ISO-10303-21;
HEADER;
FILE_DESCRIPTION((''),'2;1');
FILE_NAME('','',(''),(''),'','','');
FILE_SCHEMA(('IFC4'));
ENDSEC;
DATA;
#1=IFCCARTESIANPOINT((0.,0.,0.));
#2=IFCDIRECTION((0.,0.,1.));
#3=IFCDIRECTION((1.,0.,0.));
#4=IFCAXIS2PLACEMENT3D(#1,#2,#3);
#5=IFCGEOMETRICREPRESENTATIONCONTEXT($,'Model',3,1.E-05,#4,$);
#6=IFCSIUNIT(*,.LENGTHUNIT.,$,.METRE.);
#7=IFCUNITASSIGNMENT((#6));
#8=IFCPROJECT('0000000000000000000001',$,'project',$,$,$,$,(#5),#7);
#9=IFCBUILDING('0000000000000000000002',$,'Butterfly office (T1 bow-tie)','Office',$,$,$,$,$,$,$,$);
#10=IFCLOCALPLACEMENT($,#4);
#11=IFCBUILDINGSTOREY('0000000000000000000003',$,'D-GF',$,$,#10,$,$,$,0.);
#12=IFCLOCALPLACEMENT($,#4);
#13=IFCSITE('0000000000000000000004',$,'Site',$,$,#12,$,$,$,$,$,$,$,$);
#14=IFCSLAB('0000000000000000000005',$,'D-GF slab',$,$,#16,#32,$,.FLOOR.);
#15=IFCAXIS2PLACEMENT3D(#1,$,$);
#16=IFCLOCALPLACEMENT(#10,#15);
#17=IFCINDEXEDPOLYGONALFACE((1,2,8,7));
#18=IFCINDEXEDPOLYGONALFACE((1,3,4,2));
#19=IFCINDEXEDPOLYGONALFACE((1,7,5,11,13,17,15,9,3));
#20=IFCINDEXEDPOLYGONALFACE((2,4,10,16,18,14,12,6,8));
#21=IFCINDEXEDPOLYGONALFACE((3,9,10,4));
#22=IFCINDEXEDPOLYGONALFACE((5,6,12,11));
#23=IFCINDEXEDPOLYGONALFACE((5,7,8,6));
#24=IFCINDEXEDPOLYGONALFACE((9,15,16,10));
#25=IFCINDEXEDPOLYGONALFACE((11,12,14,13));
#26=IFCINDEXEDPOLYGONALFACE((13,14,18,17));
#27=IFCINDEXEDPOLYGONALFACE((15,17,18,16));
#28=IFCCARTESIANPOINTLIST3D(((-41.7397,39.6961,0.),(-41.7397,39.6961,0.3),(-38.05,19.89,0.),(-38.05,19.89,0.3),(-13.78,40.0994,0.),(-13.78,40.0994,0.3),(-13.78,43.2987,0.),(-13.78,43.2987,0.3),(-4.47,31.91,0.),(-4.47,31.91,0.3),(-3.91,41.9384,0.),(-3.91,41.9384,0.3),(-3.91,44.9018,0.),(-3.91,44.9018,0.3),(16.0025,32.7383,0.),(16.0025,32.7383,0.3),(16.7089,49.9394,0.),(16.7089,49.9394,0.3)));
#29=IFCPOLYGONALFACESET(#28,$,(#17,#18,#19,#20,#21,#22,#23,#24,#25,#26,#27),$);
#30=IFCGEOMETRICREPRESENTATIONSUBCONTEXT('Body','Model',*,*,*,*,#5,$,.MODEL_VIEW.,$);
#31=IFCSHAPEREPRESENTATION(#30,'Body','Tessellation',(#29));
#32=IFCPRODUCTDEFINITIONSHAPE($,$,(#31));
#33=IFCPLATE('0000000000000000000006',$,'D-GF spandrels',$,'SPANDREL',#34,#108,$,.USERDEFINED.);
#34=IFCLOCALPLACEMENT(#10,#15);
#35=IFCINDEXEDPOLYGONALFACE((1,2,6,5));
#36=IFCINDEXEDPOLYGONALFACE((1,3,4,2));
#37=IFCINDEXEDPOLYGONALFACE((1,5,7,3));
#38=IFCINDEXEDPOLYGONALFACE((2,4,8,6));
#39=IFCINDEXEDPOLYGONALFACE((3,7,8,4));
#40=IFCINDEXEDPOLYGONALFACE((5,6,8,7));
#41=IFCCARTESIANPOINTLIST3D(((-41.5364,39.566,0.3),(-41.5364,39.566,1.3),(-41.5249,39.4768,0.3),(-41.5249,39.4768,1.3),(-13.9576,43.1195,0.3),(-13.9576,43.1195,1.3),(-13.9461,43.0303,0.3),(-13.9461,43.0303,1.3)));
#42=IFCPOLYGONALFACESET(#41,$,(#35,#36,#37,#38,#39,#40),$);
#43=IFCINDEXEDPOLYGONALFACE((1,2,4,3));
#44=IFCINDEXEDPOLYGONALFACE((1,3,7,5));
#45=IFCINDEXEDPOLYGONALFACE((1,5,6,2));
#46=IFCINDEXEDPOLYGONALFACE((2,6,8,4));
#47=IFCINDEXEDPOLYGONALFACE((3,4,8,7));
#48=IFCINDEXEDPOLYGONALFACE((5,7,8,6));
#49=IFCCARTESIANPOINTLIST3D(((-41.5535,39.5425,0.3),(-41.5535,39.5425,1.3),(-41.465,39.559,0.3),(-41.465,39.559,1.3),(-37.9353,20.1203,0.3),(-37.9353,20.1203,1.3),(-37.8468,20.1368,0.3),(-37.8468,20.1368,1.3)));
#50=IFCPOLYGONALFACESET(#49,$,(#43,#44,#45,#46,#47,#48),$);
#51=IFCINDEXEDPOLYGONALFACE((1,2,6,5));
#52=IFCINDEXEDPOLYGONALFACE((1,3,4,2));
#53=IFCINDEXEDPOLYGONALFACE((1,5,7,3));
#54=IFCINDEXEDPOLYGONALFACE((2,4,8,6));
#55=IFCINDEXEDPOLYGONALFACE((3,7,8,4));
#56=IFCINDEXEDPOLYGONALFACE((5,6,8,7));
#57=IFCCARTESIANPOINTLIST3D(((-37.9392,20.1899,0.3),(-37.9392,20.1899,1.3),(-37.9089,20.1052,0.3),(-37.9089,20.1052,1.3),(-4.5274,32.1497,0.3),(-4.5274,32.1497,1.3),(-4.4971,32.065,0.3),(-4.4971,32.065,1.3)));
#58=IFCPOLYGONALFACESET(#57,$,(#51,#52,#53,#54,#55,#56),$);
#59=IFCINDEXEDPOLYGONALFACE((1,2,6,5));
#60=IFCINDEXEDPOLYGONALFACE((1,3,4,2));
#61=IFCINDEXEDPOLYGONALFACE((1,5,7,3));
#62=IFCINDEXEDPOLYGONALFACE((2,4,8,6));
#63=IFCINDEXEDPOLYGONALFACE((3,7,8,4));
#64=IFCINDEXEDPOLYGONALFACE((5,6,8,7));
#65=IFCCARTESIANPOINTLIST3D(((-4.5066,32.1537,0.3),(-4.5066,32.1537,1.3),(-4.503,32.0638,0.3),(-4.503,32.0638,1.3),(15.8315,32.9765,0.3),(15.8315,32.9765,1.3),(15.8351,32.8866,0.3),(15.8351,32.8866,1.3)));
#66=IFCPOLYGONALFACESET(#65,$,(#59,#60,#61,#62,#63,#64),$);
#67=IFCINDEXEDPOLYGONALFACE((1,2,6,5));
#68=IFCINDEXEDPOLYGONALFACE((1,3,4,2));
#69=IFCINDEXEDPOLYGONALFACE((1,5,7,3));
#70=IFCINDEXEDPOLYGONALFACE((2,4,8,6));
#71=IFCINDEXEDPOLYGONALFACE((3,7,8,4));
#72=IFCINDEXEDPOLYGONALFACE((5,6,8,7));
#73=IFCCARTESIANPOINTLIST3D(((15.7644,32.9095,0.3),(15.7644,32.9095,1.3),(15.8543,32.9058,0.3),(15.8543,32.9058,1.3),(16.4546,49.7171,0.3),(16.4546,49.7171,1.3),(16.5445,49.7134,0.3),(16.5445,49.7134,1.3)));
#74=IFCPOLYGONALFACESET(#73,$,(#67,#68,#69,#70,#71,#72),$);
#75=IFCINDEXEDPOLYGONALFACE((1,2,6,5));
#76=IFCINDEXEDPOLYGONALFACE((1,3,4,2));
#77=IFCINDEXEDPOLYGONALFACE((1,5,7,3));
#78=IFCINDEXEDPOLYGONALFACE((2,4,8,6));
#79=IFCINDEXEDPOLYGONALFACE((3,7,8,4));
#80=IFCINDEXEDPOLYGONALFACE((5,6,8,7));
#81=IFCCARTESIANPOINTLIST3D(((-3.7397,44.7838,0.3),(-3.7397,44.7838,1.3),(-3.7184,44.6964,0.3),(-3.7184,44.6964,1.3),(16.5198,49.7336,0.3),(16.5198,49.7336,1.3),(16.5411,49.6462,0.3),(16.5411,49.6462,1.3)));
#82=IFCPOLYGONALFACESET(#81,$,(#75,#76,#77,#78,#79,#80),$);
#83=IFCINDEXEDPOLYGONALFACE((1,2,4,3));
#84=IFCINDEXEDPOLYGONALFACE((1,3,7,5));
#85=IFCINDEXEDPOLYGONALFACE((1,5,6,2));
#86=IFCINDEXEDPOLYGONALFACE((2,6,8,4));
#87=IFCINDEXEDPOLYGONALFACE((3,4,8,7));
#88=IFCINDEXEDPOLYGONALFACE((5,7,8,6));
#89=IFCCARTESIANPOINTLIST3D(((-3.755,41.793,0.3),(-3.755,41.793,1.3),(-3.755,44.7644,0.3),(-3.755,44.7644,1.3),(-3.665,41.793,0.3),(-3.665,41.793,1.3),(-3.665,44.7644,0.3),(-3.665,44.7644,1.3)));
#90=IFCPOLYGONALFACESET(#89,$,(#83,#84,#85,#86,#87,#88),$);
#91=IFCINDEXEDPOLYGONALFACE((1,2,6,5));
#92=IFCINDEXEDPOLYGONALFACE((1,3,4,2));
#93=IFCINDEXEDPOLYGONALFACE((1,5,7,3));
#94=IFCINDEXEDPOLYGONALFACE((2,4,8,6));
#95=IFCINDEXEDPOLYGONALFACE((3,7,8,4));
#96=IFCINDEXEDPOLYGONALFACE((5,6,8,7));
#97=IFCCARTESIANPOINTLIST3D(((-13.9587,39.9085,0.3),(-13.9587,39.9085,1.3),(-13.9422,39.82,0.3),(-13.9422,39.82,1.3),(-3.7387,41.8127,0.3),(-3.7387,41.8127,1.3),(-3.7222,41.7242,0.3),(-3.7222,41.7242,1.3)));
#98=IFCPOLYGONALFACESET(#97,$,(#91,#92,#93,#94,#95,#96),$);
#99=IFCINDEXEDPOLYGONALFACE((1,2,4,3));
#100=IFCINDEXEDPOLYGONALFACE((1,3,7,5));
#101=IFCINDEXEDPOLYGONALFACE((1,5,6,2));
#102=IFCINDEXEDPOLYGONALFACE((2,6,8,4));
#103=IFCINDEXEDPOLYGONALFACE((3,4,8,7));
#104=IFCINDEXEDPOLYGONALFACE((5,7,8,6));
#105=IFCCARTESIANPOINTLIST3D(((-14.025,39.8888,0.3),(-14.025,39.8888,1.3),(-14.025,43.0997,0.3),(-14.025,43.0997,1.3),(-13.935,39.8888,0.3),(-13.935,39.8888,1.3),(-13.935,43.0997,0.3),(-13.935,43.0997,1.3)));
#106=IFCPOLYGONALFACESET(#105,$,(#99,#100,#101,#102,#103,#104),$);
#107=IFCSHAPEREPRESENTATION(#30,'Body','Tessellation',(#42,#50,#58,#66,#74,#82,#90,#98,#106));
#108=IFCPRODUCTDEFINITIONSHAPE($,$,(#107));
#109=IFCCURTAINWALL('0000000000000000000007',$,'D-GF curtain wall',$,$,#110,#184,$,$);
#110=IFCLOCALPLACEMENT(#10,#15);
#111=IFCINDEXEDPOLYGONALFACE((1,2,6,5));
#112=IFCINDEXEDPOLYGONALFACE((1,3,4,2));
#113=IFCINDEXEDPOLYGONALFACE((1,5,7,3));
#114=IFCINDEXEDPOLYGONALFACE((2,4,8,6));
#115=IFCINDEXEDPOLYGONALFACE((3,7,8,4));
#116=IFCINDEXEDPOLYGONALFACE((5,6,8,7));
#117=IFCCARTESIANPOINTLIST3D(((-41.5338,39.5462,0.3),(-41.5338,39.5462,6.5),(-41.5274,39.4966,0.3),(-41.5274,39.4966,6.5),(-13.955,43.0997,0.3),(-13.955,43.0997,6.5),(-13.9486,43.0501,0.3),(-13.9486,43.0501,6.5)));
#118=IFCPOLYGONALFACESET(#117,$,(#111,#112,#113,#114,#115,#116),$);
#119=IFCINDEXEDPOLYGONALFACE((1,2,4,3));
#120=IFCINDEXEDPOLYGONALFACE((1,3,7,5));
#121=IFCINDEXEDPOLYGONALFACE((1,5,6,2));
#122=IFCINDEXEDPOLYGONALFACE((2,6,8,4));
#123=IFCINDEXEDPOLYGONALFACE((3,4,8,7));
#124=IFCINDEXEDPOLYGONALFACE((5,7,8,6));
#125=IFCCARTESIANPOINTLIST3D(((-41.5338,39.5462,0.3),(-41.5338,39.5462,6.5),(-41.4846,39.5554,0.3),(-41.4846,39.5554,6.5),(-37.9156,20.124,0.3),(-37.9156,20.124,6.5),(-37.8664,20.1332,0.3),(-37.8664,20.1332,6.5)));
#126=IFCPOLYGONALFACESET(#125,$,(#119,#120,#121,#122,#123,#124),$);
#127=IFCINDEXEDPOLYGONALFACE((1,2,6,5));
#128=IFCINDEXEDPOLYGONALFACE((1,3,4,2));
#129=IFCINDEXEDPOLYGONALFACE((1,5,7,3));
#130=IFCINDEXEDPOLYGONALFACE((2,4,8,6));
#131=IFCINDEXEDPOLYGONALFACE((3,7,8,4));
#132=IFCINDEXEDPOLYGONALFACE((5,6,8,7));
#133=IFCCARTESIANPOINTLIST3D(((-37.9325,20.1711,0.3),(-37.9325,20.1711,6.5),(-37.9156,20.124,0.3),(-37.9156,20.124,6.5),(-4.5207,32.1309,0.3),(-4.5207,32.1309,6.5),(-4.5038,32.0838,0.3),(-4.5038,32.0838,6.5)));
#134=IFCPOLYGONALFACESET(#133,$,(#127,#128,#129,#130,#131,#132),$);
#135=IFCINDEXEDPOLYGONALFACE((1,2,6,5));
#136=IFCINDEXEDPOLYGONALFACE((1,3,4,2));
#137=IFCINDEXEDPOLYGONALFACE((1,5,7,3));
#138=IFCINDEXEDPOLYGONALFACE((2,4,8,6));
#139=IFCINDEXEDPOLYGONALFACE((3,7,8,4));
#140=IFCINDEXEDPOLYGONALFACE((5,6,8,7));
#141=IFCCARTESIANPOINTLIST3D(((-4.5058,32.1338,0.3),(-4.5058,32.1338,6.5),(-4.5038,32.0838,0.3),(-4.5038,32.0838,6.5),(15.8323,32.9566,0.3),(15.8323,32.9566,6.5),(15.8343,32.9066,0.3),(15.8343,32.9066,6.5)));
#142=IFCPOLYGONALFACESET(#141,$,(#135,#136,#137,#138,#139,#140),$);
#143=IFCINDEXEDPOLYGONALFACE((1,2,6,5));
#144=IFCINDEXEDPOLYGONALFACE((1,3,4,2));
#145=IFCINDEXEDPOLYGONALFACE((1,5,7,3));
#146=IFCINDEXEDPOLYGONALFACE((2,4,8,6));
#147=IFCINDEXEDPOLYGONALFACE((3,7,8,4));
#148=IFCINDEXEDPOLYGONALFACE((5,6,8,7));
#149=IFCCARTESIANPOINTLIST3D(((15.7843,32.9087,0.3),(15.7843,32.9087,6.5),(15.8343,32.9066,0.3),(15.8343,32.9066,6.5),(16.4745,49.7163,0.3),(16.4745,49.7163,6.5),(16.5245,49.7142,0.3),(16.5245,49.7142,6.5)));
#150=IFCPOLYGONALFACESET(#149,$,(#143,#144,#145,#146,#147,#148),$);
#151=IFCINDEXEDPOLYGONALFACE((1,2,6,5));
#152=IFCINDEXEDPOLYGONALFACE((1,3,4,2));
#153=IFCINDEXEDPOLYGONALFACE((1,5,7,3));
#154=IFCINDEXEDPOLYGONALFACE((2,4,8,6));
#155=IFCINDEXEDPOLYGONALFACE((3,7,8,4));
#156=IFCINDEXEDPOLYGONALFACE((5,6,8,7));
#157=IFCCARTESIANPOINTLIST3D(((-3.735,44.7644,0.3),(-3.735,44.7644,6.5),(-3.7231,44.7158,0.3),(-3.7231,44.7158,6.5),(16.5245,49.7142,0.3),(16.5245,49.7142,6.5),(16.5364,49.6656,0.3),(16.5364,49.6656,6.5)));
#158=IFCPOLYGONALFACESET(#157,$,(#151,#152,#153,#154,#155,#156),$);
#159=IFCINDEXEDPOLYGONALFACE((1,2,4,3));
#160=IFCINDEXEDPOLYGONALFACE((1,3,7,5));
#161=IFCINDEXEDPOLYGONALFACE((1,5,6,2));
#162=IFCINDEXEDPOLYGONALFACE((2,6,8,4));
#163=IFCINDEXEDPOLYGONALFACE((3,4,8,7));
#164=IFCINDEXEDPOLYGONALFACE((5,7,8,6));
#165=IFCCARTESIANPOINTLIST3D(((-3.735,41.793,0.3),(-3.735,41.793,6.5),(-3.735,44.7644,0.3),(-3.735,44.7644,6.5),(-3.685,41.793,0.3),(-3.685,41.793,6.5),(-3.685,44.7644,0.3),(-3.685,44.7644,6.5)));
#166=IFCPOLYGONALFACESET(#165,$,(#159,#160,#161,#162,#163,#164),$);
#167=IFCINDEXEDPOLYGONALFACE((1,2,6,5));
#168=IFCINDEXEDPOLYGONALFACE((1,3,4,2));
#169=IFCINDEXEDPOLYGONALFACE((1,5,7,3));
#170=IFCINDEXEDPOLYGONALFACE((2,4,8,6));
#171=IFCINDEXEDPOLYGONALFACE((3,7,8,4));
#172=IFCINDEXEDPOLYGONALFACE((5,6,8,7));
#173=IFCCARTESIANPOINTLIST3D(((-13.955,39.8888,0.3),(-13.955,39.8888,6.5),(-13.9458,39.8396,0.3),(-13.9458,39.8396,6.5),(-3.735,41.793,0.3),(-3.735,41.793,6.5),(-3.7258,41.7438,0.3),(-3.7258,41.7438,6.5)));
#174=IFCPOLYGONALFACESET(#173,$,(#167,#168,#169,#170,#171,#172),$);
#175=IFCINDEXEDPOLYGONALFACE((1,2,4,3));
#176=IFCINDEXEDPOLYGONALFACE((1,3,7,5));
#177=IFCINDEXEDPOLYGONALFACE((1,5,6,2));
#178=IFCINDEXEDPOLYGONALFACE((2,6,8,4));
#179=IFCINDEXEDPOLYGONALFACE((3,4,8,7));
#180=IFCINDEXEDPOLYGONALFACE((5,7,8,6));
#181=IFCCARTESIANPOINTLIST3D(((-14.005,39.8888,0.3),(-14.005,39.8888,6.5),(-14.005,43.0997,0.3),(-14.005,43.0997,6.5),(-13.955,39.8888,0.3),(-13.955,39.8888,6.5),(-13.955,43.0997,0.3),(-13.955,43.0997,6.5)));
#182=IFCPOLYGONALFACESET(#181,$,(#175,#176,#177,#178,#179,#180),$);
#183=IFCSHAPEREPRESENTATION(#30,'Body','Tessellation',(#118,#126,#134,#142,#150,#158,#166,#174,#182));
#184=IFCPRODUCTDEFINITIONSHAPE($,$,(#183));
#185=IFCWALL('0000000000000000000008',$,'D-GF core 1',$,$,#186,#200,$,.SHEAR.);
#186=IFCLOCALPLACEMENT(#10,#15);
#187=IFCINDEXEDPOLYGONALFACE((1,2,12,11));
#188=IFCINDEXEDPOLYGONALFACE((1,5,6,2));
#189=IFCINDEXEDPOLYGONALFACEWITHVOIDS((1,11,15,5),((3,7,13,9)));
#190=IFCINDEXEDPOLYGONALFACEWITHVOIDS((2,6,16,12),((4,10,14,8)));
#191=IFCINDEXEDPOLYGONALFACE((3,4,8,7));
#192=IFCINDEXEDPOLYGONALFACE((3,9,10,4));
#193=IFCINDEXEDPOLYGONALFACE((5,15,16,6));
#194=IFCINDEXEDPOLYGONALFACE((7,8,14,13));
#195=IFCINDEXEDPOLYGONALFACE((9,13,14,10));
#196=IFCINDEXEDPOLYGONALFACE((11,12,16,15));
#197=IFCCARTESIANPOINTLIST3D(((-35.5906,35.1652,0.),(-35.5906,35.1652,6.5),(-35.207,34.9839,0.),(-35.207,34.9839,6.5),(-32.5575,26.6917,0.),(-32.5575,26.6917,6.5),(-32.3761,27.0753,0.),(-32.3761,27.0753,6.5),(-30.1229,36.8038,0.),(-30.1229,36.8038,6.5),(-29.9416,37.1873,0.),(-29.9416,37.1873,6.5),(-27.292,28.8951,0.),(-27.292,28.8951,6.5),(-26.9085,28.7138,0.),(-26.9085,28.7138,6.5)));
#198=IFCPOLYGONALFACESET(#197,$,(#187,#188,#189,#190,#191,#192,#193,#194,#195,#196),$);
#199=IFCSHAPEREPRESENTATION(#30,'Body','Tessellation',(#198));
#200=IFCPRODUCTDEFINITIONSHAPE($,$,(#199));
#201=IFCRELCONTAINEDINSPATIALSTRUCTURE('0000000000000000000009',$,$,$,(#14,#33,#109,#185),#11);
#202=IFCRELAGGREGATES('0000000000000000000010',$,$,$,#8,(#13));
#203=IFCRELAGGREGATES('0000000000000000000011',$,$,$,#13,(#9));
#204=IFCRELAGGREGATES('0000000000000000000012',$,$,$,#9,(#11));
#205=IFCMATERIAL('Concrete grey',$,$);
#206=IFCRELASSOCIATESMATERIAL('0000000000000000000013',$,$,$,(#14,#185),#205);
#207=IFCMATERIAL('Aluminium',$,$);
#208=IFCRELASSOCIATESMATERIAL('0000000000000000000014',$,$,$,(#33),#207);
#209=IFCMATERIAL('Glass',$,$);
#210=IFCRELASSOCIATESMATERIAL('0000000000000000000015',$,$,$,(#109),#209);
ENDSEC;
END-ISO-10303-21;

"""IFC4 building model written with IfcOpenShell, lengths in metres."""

from ifc_helpers import new_model, si_unit, frame, origin_with_axes, place, context, subcontext, project, spatial, polyline, outline, extrude, material, element, save


model = new_model("IFC4")

# Units and contexts
model_context = context("Model", 3, precision=1e-05, world=origin_with_axes())
body_context = subcontext(model_context, "Body", "Model", "MODEL_VIEW")
ifc_project = project(units=[si_unit("LENGTHUNIT", "METRE")], contexts=[model_context])

# Site, building, storey
site_placement = place(None, origin_with_axes())
site = spatial("IfcSite", under=ifc_project, at=site_placement, Name="Site")
building = spatial("IfcBuilding", under=site, Name="Butterfly office (T1 bow-tie)", Description="Office")
storey_placement = place(None, origin_with_axes())
storey = spatial("IfcBuildingStorey", under=building, at=storey_placement, Name="D-GF", Elevation=0.0)

# Shared definitions
ifc_material_1 = material(Name="Aluminium")

# Slab
ifc_material_2 = material(Name="Concrete grey")
slab_placement = place(storey_placement, origin_with_axes())
element("IfcSlab", 1, at=slab_placement, inside=storey, material=ifc_material_2, Name="D-GF slab", PredefinedType="FLOOR", context=body_context, shape_type="SweptSolid", body=[
    extrude(outline(polyline([(-13.78, 43.2987), (-41.7397, 39.6961), (-38.05, 19.89), (-4.47, 31.91), (16.0025, 32.7383), (16.7089, 49.9394), (-3.91, 44.9018), (-3.91, 41.9384), (-13.78, 40.0994), (-13.78, 43.2987)])), origin_with_axes(), (0.0, 0.0, 1.0), 0.3),
])

# Plate
plate_placement = place(storey_placement, origin_with_axes())
element("IfcPlate", 2, at=plate_placement, inside=storey, material=ifc_material_1, Name="D-GF spandrels", ObjectType="SPANDREL", PredefinedType="USERDEFINED", context=body_context, shape_type="SweptSolid", body=[
    extrude(outline(polyline([(-13.9576, 43.1195), (-41.5364, 39.566), (-41.5249, 39.4768), (-13.9461, 43.0303), (-13.9576, 43.1195)])), frame((0.0, 0.0, 0.3), z_axis=(0.0, 0.0, 1.0), x_axis=(1.0, 0.0, 0.0)), (0.0, 0.0, 1.0), 1.0),
    extrude(outline(polyline([(-41.5535, 39.5425), (-37.9353, 20.1203), (-37.8468, 20.1368), (-41.465, 39.559), (-41.5535, 39.5425)])), frame((0.0, 0.0, 0.3), z_axis=(0.0, 0.0, 1.0), x_axis=(1.0, 0.0, 0.0)), (0.0, 0.0, 1.0), 1.0),
    extrude(outline(polyline([(-37.9089, 20.1052), (-4.4971, 32.065), (-4.5274, 32.1497), (-37.9392, 20.1899), (-37.9089, 20.1052)])), frame((0.0, 0.0, 0.3), z_axis=(0.0, 0.0, 1.0), x_axis=(1.0, 0.0, 0.0)), (0.0, 0.0, 1.0), 1.0),
    extrude(outline(polyline([(-4.503, 32.0638), (15.8351, 32.8866), (15.8315, 32.9765), (-4.5066, 32.1537), (-4.503, 32.0638)])), frame((0.0, 0.0, 0.3), z_axis=(0.0, 0.0, 1.0), x_axis=(1.0, 0.0, 0.0)), (0.0, 0.0, 1.0), 1.0),
    extrude(outline(polyline([(15.8543, 32.9058), (16.5445, 49.7134), (16.4546, 49.7171), (15.7644, 32.9095), (15.8543, 32.9058)])), frame((0.0, 0.0, 0.3), z_axis=(0.0, 0.0, 1.0), x_axis=(1.0, 0.0, 0.0)), (0.0, 0.0, 1.0), 1.0),
    extrude(outline(polyline([(16.5198, 49.7336), (-3.7397, 44.7838), (-3.7184, 44.6964), (16.5411, 49.6462), (16.5198, 49.7336)])), frame((0.0, 0.0, 0.3), z_axis=(0.0, 0.0, 1.0), x_axis=(1.0, 0.0, 0.0)), (0.0, 0.0, 1.0), 1.0),
    extrude(outline(polyline([(-3.755, 44.7644), (-3.755, 41.793), (-3.665, 41.793), (-3.665, 44.7644), (-3.755, 44.7644)])), frame((0.0, 0.0, 0.3), z_axis=(0.0, 0.0, 1.0), x_axis=(1.0, 0.0, 0.0)), (0.0, 0.0, 1.0), 1.0),
    extrude(outline(polyline([(-3.7387, 41.8127), (-13.9587, 39.9085), (-13.9422, 39.82), (-3.7222, 41.7242), (-3.7387, 41.8127)])), frame((0.0, 0.0, 0.3), z_axis=(0.0, 0.0, 1.0), x_axis=(1.0, 0.0, 0.0)), (0.0, 0.0, 1.0), 1.0),
    extrude(outline(polyline([(-13.935, 39.8888), (-13.935, 43.0997), (-14.025, 43.0997), (-14.025, 39.8888), (-13.935, 39.8888)])), frame((0.0, 0.0, 0.3), z_axis=(0.0, 0.0, 1.0), x_axis=(1.0, 0.0, 0.0)), (0.0, 0.0, 1.0), 1.0),
])

# Curtain wall
ifc_material_3 = material(Name="Glass")
curtain_wall_placement = place(storey_placement, origin_with_axes())
element("IfcCurtainWall", 3, at=curtain_wall_placement, inside=storey, material=ifc_material_3, Name="D-GF curtain wall", context=body_context, shape_type="SweptSolid", body=[
    extrude(outline(polyline([(-13.955, 43.0997), (-41.5338, 39.5462), (-41.5274, 39.4966), (-13.9486, 43.0501), (-13.955, 43.0997)])), frame((0.0, 0.0, 0.3), z_axis=(0.0, 0.0, 1.0), x_axis=(1.0, 0.0, 0.0)), (0.0, 0.0, 1.0), 6.2),
    extrude(outline(polyline([(-41.5338, 39.5462), (-37.9156, 20.124), (-37.8664, 20.1332), (-41.4846, 39.5554), (-41.5338, 39.5462)])), frame((0.0, 0.0, 0.3), z_axis=(0.0, 0.0, 1.0), x_axis=(1.0, 0.0, 0.0)), (0.0, 0.0, 1.0), 6.2),
    extrude(outline(polyline([(-37.9156, 20.124), (-4.5038, 32.0838), (-4.5207, 32.1309), (-37.9325, 20.1711), (-37.9156, 20.124)])), frame((0.0, 0.0, 0.3), z_axis=(0.0, 0.0, 1.0), x_axis=(1.0, 0.0, 0.0)), (0.0, 0.0, 1.0), 6.2),
    extrude(outline(polyline([(-4.5038, 32.0838), (15.8343, 32.9066), (15.8323, 32.9566), (-4.5058, 32.1338), (-4.5038, 32.0838)])), frame((0.0, 0.0, 0.3), z_axis=(0.0, 0.0, 1.0), x_axis=(1.0, 0.0, 0.0)), (0.0, 0.0, 1.0), 6.2),
    extrude(outline(polyline([(15.8343, 32.9066), (16.5245, 49.7142), (16.4745, 49.7163), (15.7843, 32.9087), (15.8343, 32.9066)])), frame((0.0, 0.0, 0.3), z_axis=(0.0, 0.0, 1.0), x_axis=(1.0, 0.0, 0.0)), (0.0, 0.0, 1.0), 6.2),
    extrude(outline(polyline([(16.5245, 49.7142), (-3.735, 44.7644), (-3.7231, 44.7158), (16.5364, 49.6656), (16.5245, 49.7142)])), frame((0.0, 0.0, 0.3), z_axis=(0.0, 0.0, 1.0), x_axis=(1.0, 0.0, 0.0)), (0.0, 0.0, 1.0), 6.2),
    extrude(outline(polyline([(-3.735, 44.7644), (-3.735, 41.793), (-3.685, 41.793), (-3.685, 44.7644), (-3.735, 44.7644)])), frame((0.0, 0.0, 0.3), z_axis=(0.0, 0.0, 1.0), x_axis=(1.0, 0.0, 0.0)), (0.0, 0.0, 1.0), 6.2),
    extrude(outline(polyline([(-3.735, 41.793), (-13.955, 39.8888), (-13.9458, 39.8396), (-3.7258, 41.7438), (-3.735, 41.793)])), frame((0.0, 0.0, 0.3), z_axis=(0.0, 0.0, 1.0), x_axis=(1.0, 0.0, 0.0)), (0.0, 0.0, 1.0), 6.2),
    extrude(outline(polyline([(-13.955, 39.8888), (-13.955, 43.0997), (-14.005, 43.0997), (-14.005, 39.8888), (-13.955, 39.8888)])), frame((0.0, 0.0, 0.3), z_axis=(0.0, 0.0, 1.0), x_axis=(1.0, 0.0, 0.0)), (0.0, 0.0, 1.0), 6.2),
])

# Wall
wall_1_placement = place(storey_placement, origin_with_axes())
element("IfcWall", 4, at=wall_1_placement, inside=storey, material=ifc_material_2, Name="D-GF core 1", PredefinedType="SHEAR", context=body_context, shape_type="SweptSolid", body=[
    extrude(outline(polyline([(-32.5575, 26.6917), (-26.9085, 28.7138), (-29.9416, 37.1873), (-35.5906, 35.1652), (-32.5575, 26.6917)]), holes=[polyline([(-32.3761, 27.0753), (-27.292, 28.8951), (-30.1229, 36.8038), (-35.207, 34.9839), (-32.3761, 27.0753)])]), origin_with_axes(), (0.0, 0.0, 1.0), 6.5),
])

save(model, "model.ifc")
